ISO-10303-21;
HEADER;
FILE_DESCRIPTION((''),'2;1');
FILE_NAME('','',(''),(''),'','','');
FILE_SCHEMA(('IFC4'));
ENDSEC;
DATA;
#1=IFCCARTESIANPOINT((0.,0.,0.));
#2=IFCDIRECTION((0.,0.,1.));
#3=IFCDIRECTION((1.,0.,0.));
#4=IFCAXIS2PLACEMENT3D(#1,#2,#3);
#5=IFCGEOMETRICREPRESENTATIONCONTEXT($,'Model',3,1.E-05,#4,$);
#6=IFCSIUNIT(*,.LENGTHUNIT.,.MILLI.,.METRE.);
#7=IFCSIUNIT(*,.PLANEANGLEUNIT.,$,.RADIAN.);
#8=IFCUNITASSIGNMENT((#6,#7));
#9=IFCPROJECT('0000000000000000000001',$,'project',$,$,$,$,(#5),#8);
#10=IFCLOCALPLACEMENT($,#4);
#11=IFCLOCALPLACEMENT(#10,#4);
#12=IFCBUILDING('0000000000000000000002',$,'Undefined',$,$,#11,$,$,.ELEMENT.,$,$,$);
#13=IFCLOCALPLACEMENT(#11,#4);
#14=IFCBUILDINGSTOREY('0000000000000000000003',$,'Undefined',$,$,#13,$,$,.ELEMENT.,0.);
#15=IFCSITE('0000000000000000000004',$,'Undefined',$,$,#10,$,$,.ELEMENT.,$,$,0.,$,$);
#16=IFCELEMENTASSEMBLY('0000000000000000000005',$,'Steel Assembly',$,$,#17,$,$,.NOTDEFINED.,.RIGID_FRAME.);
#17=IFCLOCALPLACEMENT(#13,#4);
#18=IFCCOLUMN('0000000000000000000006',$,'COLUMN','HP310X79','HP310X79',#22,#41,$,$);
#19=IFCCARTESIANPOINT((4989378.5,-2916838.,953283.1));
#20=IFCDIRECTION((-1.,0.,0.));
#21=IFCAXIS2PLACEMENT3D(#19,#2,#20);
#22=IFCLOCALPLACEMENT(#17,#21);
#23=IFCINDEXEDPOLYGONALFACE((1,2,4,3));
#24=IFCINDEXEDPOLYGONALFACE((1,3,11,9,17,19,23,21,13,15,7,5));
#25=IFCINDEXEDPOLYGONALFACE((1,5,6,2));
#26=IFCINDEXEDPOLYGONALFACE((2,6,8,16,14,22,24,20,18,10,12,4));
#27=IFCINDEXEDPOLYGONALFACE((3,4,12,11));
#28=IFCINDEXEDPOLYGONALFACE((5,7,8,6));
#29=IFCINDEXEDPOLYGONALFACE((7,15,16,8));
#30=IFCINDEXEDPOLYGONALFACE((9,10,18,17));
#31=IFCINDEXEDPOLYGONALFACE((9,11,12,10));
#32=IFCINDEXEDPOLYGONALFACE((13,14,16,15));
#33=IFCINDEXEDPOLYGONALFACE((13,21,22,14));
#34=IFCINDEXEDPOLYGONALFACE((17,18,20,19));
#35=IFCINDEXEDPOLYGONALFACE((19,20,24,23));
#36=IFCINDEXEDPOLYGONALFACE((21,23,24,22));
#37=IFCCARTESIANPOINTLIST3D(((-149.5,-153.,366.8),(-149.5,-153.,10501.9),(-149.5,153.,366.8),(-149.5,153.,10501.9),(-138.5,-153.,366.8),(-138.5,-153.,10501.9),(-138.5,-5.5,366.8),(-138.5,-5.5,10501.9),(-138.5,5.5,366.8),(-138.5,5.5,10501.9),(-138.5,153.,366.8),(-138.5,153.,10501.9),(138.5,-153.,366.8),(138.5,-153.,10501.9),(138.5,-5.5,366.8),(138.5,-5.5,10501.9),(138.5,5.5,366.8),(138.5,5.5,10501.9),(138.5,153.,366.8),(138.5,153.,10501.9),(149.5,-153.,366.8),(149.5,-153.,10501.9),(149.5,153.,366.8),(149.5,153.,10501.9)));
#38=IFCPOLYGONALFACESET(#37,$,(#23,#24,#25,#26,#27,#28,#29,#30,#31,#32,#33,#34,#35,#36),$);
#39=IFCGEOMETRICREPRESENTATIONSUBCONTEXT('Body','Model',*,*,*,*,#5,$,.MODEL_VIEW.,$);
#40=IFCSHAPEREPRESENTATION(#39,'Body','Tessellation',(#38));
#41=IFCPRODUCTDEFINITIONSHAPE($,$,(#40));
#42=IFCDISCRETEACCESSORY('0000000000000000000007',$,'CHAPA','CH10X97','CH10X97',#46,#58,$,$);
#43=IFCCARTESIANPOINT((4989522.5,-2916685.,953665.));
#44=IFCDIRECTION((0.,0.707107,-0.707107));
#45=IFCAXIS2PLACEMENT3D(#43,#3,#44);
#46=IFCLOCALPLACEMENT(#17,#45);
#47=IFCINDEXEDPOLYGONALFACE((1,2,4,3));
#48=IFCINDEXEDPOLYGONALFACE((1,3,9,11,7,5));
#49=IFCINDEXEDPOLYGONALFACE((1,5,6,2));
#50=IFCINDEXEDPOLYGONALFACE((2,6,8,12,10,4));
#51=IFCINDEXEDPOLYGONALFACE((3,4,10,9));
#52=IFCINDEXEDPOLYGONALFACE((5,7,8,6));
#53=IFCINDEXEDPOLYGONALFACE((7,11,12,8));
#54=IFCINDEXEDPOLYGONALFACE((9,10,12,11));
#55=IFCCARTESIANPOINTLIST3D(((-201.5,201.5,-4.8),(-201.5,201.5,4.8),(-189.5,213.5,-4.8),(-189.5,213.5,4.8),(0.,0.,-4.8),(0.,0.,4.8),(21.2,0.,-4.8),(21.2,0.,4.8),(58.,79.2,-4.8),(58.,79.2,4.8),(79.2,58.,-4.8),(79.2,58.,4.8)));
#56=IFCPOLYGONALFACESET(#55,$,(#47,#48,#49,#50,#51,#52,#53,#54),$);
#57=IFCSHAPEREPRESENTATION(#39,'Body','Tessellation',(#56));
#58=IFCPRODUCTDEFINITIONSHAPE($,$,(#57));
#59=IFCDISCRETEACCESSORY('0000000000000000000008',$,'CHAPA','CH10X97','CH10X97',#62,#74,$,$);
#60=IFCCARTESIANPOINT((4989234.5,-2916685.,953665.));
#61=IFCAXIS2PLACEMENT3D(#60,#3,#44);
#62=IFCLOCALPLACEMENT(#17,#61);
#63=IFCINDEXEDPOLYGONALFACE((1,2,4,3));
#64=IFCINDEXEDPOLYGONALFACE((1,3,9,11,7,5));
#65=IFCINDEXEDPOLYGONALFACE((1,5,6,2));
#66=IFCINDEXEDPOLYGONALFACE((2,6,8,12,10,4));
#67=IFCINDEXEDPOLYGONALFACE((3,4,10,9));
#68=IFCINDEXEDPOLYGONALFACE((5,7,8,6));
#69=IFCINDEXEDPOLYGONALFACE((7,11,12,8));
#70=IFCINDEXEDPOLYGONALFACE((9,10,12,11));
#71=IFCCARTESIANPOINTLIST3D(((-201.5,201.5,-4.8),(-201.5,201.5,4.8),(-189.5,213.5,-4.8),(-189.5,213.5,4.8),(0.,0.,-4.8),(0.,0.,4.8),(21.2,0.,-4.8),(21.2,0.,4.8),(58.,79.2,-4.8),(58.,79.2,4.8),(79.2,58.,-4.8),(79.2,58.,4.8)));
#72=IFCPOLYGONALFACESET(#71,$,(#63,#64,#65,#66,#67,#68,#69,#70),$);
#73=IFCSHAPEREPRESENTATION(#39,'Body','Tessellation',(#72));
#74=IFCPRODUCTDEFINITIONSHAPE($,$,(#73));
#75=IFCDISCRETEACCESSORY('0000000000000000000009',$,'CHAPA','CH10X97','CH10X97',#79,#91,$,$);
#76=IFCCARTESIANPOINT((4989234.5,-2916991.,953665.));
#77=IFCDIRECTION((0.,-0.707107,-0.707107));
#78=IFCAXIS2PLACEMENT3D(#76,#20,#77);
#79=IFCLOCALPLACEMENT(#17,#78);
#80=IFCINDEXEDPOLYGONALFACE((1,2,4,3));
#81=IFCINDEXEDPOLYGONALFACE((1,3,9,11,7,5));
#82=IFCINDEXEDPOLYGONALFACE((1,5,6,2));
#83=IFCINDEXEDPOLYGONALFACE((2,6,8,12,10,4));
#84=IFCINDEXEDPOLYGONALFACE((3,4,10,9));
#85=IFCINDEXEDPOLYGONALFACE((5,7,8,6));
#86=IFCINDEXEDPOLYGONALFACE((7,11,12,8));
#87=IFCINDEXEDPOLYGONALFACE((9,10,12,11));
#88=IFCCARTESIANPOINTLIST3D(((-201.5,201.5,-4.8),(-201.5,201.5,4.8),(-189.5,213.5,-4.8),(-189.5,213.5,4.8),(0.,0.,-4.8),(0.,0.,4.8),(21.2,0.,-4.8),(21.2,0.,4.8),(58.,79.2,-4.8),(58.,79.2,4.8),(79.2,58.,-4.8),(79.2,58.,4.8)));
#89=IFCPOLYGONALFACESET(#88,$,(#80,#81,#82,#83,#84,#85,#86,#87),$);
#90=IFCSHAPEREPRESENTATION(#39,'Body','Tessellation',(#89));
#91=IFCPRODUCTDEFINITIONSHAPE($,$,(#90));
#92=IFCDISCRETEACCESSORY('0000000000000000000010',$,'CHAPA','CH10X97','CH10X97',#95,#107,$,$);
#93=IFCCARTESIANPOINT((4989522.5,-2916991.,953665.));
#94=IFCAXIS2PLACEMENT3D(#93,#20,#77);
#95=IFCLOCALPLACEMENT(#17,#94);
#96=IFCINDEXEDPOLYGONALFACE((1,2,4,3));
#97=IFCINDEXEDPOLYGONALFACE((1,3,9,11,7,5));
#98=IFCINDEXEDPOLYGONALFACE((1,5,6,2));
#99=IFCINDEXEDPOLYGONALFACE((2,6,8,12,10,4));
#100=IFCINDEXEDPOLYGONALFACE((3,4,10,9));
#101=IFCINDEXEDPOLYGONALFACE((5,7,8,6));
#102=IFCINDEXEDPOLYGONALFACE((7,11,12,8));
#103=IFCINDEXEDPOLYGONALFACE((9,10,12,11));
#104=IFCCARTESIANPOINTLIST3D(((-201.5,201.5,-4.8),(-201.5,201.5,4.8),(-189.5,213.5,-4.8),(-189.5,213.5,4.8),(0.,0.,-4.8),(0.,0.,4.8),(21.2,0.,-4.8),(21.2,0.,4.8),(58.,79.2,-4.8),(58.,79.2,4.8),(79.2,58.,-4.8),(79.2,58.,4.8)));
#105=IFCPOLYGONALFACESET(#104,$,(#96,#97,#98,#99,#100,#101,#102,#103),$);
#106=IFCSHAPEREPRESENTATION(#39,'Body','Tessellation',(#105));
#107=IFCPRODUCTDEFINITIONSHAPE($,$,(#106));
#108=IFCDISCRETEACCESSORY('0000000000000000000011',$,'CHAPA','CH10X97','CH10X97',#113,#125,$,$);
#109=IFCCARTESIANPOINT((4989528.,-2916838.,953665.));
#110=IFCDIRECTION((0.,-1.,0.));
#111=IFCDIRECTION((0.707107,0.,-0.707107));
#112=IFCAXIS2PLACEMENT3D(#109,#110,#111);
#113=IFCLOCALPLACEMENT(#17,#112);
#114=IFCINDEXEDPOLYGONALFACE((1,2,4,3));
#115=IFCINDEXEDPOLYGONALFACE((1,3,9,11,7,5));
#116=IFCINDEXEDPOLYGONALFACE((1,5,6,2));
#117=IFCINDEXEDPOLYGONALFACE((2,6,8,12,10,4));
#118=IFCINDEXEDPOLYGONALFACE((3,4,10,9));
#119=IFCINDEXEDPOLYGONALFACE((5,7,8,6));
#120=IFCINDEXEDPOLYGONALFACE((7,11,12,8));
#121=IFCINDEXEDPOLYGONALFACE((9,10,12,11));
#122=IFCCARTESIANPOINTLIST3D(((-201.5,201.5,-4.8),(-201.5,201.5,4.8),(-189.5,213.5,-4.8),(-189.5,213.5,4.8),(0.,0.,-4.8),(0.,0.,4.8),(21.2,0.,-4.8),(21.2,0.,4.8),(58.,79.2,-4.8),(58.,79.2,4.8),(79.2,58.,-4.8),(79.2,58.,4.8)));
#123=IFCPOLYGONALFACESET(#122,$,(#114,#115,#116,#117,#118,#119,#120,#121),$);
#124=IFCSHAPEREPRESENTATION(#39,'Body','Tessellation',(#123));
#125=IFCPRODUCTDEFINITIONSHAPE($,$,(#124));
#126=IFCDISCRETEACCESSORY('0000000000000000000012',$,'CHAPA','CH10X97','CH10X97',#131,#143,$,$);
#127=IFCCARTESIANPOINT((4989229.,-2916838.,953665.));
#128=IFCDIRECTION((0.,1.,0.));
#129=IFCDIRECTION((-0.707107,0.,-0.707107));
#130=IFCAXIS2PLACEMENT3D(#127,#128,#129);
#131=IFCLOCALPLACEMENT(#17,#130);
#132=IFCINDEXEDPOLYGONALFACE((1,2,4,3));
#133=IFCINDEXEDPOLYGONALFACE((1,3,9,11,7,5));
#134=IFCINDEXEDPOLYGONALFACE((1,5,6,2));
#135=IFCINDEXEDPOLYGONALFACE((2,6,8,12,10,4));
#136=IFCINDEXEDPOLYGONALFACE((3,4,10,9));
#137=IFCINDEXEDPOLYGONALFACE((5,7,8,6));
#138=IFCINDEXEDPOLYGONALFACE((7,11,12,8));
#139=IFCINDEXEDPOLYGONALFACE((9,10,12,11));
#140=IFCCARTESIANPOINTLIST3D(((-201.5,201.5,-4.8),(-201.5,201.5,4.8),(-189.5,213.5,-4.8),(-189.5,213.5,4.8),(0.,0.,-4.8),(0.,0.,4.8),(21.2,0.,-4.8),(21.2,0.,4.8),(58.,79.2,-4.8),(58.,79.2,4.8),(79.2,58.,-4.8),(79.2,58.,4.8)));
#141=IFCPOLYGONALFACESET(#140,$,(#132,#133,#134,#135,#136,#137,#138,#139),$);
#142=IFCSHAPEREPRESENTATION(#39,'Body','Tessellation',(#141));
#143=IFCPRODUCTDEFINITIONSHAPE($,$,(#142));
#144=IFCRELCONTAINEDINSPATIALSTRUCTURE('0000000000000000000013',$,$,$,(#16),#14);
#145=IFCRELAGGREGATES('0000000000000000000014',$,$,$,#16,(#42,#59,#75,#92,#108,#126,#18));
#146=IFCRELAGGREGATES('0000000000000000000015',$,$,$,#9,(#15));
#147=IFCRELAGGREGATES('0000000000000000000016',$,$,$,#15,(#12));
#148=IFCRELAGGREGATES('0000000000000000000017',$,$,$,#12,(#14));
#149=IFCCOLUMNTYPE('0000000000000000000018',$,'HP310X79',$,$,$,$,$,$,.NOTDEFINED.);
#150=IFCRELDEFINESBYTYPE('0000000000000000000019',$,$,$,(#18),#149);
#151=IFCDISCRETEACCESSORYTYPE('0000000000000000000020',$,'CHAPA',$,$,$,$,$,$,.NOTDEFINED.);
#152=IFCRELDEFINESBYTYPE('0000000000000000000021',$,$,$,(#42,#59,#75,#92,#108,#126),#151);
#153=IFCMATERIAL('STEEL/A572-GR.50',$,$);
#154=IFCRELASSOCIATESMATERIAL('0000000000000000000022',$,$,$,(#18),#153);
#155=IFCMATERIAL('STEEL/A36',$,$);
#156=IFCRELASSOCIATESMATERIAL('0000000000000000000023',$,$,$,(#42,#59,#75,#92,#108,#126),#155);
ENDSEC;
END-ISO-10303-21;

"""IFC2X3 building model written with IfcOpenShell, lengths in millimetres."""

from ifc_helpers import new_model, si_unit, frame, origin_with_axes, origin_2d_with_axis, place, context, subcontext, project, spatial, polyline, i_section, outline, extrude, clip, halfspace, material, type_object, element, aggregate, save


model = new_model("IFC2X3")

# Units and contexts
model_context = context("Model", 3, precision=1e-05, world=origin_with_axes())
body_context = subcontext(model_context, "Body", "Model", "MODEL_VIEW")
ifc_project = project(units=[si_unit("LENGTHUNIT", "METRE", prefix="MILLI"), si_unit("PLANEANGLEUNIT", "RADIAN")], contexts=[model_context])

# Site, building, storey
site_placement = place(None, origin_with_axes())
site = spatial("IfcSite", under=ifc_project, at=site_placement, Name="Undefined", CompositionType="ELEMENT", RefElevation=0.0)
building_placement = place(site_placement, origin_with_axes())
building = spatial("IfcBuilding", under=site, at=building_placement, Name="Undefined", CompositionType="ELEMENT")
storey_placement = place(building_placement, origin_with_axes())
storey = spatial("IfcBuildingStorey", under=building, at=storey_placement, Name="Undefined", CompositionType="ELEMENT", Elevation=0.0)

# Element assembly, column
assembly_1_placement = place(storey_placement, origin_with_axes())
assembly_1 = element("IfcElementAssembly", 1, at=assembly_1_placement, inside=storey, Name="Steel Assembly", AssemblyPlace="NOTDEFINED", PredefinedType="RIGID_FRAME")
ifc_material_1 = material(Name="STEEL/A572-GR.50")
column_type = type_object("IfcColumnType", Name="HP310X79", PredefinedType="NOTDEFINED")
column_placement = place(assembly_1_placement, frame((4989378.5, -2916838.0, 953283.1), z_axis=(0.0, 0.0, 1.0), x_axis=(-1.0, 0.0, 0.0)))
column = element("IfcColumn", 2, at=column_placement, type_object=column_type, material=ifc_material_1, Name="COLUMN", Description="HP310X79", ObjectType="HP310X79", context=body_context, shape_type="Clipping", body=[
    clip(clip(clip(clip(clip(clip(extrude(i_section(OverallWidth=306.0, OverallDepth=299.0, WebThickness=11.0, FlangeThickness=11.0, at=origin_2d_with_axis()), frame((0.0, 0.0, 10868.8), z_axis=(0.0, 0.0, -1.0), x_axis=(0.0, 1.0, 0.0)), (0.0, 0.0, 1.0), 10502.0), halfspace(frame((-149.5, 153.0, 10501.9), z_axis=(0.0, 0.0, 1.0), x_axis=(1.0, 0.0, 0.0)), False)), halfspace(frame((-149.5, 153.0, 10501.9), z_axis=(0.0, 0.0, 1.0), x_axis=(1.0, 0.0, 0.0)), False)), halfspace(frame((-149.5, -153.0, 366.9), z_axis=(0.0, 0.0, -1.0), x_axis=(1.0, 0.0, 0.0)), False)), halfspace(frame((-149.5, 153.0, 10501.9), z_axis=(0.0, 0.0, 1.0), x_axis=(1.0, 0.0, 0.0)), False)), halfspace(frame((-149.5, 153.0, 10501.9), z_axis=(0.0, 0.0, 1.0), x_axis=(1.0, 0.0, 0.0)), False)), halfspace(frame((-149.5, 0.0, 366.9), z_axis=(0.0, 0.0, 1.0), x_axis=(0.0, 1.0, 0.0)), True)),
])

# Shared definitions
ifc_material_2 = material(Name="STEEL/A36")
discrete_accessory_type_1 = type_object("IfcDiscreteAccessoryType", Name="CHAPA")

# Discrete accessories
discrete_accessory_1_placement = place(assembly_1_placement, frame((4989522.5, -2916685.0, 953665.0), z_axis=(1.0, 0.0, 0.0), x_axis=(0.0, 0.707107, -0.707107)))
discrete_accessory_1 = element("IfcDiscreteAccessory", 3, at=discrete_accessory_1_placement, type_object=discrete_accessory_type_1, material=ifc_material_2, Name="CHAPA", Description="CH10X97", ObjectType="CH10X97", context=body_context, shape_type="SweptSolid", body=[
    extrude(outline(polyline([(0.0, 0.0), (21.2, 0.0), (79.2, 58.0), (58.0, 79.2), (-189.5, 213.5), (-201.5, 201.5), (0.0, 0.0)])), frame((0.0, 0.0, -4.8), z_axis=(0.0, 0.0, 1.0), x_axis=(1.0, 0.0, 0.0)), (0.0, 0.0, 1.0), 9.5),
])
discrete_accessory_2_placement = place(assembly_1_placement, frame((4989234.5, -2916685.0, 953665.0), z_axis=(1.0, 0.0, 0.0), x_axis=(0.0, 0.707107, -0.707107)))
discrete_accessory_2 = element("IfcDiscreteAccessory", 4, at=discrete_accessory_2_placement, type_object=discrete_accessory_type_1, material=ifc_material_2, Name="CHAPA", Description="CH10X97", ObjectType="CH10X97", context=body_context, shape_type="SweptSolid", body=[
    extrude(outline(polyline([(0.0, 0.0), (21.2, 0.0), (79.2, 58.0), (58.0, 79.2), (-189.5, 213.5), (-201.5, 201.5), (0.0, 0.0)])), frame((0.0, 0.0, -4.8), z_axis=(0.0, 0.0, 1.0), x_axis=(1.0, 0.0, 0.0)), (0.0, 0.0, 1.0), 9.5),
])
discrete_accessory_3_placement = place(assembly_1_placement, frame((4989234.5, -2916991.0, 953665.0), z_axis=(-1.0, 0.0, 0.0), x_axis=(0.0, -0.707107, -0.707107)))
discrete_accessory_3 = element("IfcDiscreteAccessory", 5, at=discrete_accessory_3_placement, type_object=discrete_accessory_type_1, material=ifc_material_2, Name="CHAPA", Description="CH10X97", ObjectType="CH10X97", context=body_context, shape_type="SweptSolid", body=[
    extrude(outline(polyline([(0.0, 0.0), (21.2, 0.0), (79.2, 58.0), (58.0, 79.2), (-189.5, 213.5), (-201.5, 201.5), (0.0, 0.0)])), frame((0.0, 0.0, -4.8), z_axis=(0.0, 0.0, 1.0), x_axis=(1.0, 0.0, 0.0)), (0.0, 0.0, 1.0), 9.5),
])
discrete_accessory_4_placement = place(assembly_1_placement, frame((4989522.5, -2916991.0, 953665.0), z_axis=(-1.0, 0.0, 0.0), x_axis=(0.0, -0.707107, -0.707107)))
discrete_accessory_4 = element("IfcDiscreteAccessory", 6, at=discrete_accessory_4_placement, type_object=discrete_accessory_type_1, material=ifc_material_2, Name="CHAPA", Description="CH10X97", ObjectType="CH10X97", context=body_context, shape_type="SweptSolid", body=[
    extrude(outline(polyline([(0.0, 0.0), (21.2, 0.0), (79.2, 58.0), (58.0, 79.2), (-189.5, 213.5), (-201.5, 201.5), (0.0, 0.0)])), frame((0.0, 0.0, -4.8), z_axis=(0.0, 0.0, 1.0), x_axis=(1.0, 0.0, 0.0)), (0.0, 0.0, 1.0), 9.5),
])
discrete_accessory_5_placement = place(assembly_1_placement, frame((4989528.0, -2916838.0, 953665.0), z_axis=(0.0, -1.0, 0.0), x_axis=(0.707107, 0.0, -0.707107)))
discrete_accessory_5 = element("IfcDiscreteAccessory", 7, at=discrete_accessory_5_placement, type_object=discrete_accessory_type_1, material=ifc_material_2, Name="CHAPA", Description="CH10X97", ObjectType="CH10X97", context=body_context, shape_type="SweptSolid", body=[
    extrude(outline(polyline([(0.0, 0.0), (21.2, 0.0), (79.2, 58.0), (58.0, 79.2), (-189.5, 213.5), (-201.5, 201.5), (0.0, 0.0)])), frame((0.0, 0.0, -4.8), z_axis=(0.0, 0.0, 1.0), x_axis=(1.0, 0.0, 0.0)), (0.0, 0.0, 1.0), 9.5),
])
discrete_accessory_6_placement = place(assembly_1_placement, frame((4989229.0, -2916838.0, 953665.0), z_axis=(0.0, 1.0, 0.0), x_axis=(-0.707107, 0.0, -0.707107)))
discrete_accessory_6 = element("IfcDiscreteAccessory", 8, at=discrete_accessory_6_placement, type_object=discrete_accessory_type_1, material=ifc_material_2, Name="CHAPA", Description="CH10X97", ObjectType="CH10X97", context=body_context, shape_type="SweptSolid", body=[
    extrude(outline(polyline([(0.0, 0.0), (21.2, 0.0), (79.2, 58.0), (58.0, 79.2), (-189.5, 213.5), (-201.5, 201.5), (0.0, 0.0)])), frame((0.0, 0.0, -4.8), z_axis=(0.0, 0.0, 1.0), x_axis=(1.0, 0.0, 0.0)), (0.0, 0.0, 1.0), 9.5),
])

aggregate(assembly_1, [discrete_accessory_1, discrete_accessory_2, discrete_accessory_3, discrete_accessory_4, discrete_accessory_5, discrete_accessory_6, column])

save(model, "model.ifc")
